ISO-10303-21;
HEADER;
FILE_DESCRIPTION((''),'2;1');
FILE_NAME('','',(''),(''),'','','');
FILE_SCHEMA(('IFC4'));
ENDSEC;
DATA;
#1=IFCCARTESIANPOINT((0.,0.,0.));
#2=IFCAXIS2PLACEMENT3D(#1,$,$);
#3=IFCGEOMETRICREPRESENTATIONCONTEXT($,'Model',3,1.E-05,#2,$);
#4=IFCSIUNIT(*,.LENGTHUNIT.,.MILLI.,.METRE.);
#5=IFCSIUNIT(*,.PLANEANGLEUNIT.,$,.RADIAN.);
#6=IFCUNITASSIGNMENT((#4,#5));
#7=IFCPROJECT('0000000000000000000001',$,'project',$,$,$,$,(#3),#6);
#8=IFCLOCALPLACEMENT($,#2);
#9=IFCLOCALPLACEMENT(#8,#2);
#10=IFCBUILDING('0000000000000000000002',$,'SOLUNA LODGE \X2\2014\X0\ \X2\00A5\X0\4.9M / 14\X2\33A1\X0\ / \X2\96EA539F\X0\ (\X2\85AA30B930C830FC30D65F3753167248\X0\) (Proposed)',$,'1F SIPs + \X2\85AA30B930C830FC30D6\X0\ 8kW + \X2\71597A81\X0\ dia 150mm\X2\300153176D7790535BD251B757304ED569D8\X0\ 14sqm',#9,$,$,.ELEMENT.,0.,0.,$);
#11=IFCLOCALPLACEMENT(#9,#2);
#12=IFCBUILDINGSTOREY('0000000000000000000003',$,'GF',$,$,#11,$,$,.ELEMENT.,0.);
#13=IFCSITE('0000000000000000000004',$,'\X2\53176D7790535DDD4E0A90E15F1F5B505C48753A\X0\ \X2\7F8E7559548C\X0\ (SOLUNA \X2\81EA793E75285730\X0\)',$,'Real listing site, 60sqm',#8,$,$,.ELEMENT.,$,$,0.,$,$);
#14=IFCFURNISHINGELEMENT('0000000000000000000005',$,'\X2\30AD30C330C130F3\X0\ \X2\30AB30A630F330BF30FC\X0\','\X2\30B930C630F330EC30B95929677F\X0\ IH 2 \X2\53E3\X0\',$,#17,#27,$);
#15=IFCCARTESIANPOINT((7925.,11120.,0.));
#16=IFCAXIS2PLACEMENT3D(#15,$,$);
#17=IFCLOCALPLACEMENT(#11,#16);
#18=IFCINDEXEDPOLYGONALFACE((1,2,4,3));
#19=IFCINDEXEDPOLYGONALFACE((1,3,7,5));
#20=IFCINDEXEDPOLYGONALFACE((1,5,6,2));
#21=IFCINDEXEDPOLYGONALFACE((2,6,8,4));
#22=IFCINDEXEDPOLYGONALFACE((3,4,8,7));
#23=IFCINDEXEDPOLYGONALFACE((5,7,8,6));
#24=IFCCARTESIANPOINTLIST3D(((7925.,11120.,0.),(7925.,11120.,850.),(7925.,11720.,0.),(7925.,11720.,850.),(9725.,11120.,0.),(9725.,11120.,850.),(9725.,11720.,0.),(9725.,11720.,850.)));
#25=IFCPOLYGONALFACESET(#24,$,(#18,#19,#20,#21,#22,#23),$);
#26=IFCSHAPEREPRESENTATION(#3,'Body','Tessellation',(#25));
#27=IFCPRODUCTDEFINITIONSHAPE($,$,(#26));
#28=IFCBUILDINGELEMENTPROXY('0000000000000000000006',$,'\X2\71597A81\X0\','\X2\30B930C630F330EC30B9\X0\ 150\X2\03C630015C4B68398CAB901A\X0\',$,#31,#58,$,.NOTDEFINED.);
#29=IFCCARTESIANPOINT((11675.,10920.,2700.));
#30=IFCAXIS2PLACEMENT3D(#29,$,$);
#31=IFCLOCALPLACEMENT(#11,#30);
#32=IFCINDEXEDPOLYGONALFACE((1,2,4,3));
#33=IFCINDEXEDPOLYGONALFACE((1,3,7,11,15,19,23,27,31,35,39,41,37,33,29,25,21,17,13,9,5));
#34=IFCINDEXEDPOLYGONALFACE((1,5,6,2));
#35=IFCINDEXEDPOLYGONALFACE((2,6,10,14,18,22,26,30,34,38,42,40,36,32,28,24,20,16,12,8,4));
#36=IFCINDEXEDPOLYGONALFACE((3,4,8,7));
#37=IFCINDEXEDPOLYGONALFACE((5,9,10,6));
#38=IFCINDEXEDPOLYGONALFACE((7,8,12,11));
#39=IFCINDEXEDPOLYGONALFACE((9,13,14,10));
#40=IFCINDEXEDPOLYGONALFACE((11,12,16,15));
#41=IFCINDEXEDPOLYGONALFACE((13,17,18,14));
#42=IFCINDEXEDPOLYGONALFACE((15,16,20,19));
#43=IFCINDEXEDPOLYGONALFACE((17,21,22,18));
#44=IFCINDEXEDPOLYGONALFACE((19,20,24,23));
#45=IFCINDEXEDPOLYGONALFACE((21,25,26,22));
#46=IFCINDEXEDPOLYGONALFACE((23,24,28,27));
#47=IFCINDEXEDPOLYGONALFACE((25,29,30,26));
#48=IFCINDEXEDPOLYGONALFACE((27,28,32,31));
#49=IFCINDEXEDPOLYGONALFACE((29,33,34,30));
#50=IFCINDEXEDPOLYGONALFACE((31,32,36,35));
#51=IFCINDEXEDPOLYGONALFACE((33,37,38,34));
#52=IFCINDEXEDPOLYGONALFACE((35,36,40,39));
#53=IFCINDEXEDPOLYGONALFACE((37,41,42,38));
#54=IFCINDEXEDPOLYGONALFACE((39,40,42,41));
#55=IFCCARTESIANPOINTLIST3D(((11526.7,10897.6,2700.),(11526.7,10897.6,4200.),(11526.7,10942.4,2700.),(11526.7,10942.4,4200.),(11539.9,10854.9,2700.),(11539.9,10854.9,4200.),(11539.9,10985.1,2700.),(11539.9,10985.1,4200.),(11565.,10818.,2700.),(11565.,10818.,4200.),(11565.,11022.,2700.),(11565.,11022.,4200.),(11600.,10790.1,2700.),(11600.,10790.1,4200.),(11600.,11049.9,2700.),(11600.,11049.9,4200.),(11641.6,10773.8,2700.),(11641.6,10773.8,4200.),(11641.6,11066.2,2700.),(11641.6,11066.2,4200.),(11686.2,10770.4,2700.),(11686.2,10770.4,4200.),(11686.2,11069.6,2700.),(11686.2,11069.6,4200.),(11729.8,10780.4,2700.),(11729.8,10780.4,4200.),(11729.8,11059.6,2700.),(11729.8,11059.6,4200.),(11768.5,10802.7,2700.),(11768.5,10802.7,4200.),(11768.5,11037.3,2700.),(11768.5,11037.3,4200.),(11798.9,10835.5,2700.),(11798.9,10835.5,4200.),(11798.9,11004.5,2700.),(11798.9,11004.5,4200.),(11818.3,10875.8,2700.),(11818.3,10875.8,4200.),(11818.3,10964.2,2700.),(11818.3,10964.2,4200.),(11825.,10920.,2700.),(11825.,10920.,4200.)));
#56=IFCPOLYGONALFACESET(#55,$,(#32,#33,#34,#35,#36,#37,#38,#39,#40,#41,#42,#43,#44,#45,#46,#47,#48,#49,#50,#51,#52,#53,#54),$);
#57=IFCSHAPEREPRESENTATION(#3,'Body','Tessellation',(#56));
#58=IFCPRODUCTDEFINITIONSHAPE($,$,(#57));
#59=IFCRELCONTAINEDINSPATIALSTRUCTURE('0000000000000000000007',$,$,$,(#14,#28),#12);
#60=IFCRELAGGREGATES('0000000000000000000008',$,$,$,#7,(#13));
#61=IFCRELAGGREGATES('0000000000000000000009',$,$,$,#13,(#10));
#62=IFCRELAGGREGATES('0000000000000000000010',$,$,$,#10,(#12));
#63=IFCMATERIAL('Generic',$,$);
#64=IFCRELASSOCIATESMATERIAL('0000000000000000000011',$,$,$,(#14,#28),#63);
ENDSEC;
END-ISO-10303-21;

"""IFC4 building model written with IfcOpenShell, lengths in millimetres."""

from ifc_helpers import new_model, si_unit, frame, frame_2d, origin, origin_2d, place, context, project, spatial, rectangle, circle, extrude, material, element, save


model = new_model("IFC4")

# Units and contexts
model_context = context("Model", 3, precision=1e-05, world=origin())
ifc_project = project(units=[si_unit("LENGTHUNIT", "METRE", prefix="MILLI"), si_unit("PLANEANGLEUNIT", "RADIAN")], contexts=[model_context])

# Site, building, storey
site_placement = place(None, origin())
site = spatial("IfcSite", under=ifc_project, at=site_placement, Name="北海道川上郡弟子屈町 美留和 (SOLUNA 自社用地)", ObjectType="Real listing site, 60sqm", CompositionType="ELEMENT", RefElevation=0.0)
building_placement = place(site_placement, origin())
building = spatial("IfcBuilding", under=site, at=building_placement, Name="SOLUNA LODGE — ¥4.9M / 14㎡ / 雪原 (薪ストーブ強化版) (Proposed)", ObjectType="1F SIPs + 薪ストーブ 8kW + 煙突 dia 150mm、北海道寒冷地仕様 14sqm", CompositionType="ELEMENT", ElevationOfRefHeight=0.0, ElevationOfTerrain=0.0)
storey_placement = place(building_placement, origin())
storey = spatial("IfcBuildingStorey", under=building, at=storey_placement, Name="GF", CompositionType="ELEMENT", Elevation=0.0)

# Shared definitions
ifc_material = material(Name="Generic")

# Furnishing element
furnishing_1_placement = place(storey_placement, frame((7925.0, 11120.0, 0.0)))
element("IfcFurnishingElement", 1, at=furnishing_1_placement, inside=storey, material=ifc_material, Name="キッチン カウンター", Description="ステンレス天板 IH 2 口", context=model_context, shape_type="SweptSolid", body=[
    extrude(rectangle(XDim=1800.0, YDim=600.0, at=frame_2d((900.0, 300.0))), frame((7925.0, 11120.0, 0.0)), (0.0, 0.0, 1.0), 850.0),
])

# Building element proxy
proxy_placement = place(storey_placement, frame((11675.0, 10920.0, 2700.0)))
element("IfcBuildingElementProxy", 2, at=proxy_placement, inside=storey, material=ifc_material, Name="煙突", Description="ステンレス 150φ、屋根貫通", PredefinedType="NOTDEFINED", context=model_context, shape_type="SweptSolid", body=[
    extrude(circle(Radius=150.0, at=origin_2d()), frame((11675.0, 10920.0, 2700.0)), (0.0, 0.0, 1.0), 1500.0),
])

save(model, "model.ifc")
